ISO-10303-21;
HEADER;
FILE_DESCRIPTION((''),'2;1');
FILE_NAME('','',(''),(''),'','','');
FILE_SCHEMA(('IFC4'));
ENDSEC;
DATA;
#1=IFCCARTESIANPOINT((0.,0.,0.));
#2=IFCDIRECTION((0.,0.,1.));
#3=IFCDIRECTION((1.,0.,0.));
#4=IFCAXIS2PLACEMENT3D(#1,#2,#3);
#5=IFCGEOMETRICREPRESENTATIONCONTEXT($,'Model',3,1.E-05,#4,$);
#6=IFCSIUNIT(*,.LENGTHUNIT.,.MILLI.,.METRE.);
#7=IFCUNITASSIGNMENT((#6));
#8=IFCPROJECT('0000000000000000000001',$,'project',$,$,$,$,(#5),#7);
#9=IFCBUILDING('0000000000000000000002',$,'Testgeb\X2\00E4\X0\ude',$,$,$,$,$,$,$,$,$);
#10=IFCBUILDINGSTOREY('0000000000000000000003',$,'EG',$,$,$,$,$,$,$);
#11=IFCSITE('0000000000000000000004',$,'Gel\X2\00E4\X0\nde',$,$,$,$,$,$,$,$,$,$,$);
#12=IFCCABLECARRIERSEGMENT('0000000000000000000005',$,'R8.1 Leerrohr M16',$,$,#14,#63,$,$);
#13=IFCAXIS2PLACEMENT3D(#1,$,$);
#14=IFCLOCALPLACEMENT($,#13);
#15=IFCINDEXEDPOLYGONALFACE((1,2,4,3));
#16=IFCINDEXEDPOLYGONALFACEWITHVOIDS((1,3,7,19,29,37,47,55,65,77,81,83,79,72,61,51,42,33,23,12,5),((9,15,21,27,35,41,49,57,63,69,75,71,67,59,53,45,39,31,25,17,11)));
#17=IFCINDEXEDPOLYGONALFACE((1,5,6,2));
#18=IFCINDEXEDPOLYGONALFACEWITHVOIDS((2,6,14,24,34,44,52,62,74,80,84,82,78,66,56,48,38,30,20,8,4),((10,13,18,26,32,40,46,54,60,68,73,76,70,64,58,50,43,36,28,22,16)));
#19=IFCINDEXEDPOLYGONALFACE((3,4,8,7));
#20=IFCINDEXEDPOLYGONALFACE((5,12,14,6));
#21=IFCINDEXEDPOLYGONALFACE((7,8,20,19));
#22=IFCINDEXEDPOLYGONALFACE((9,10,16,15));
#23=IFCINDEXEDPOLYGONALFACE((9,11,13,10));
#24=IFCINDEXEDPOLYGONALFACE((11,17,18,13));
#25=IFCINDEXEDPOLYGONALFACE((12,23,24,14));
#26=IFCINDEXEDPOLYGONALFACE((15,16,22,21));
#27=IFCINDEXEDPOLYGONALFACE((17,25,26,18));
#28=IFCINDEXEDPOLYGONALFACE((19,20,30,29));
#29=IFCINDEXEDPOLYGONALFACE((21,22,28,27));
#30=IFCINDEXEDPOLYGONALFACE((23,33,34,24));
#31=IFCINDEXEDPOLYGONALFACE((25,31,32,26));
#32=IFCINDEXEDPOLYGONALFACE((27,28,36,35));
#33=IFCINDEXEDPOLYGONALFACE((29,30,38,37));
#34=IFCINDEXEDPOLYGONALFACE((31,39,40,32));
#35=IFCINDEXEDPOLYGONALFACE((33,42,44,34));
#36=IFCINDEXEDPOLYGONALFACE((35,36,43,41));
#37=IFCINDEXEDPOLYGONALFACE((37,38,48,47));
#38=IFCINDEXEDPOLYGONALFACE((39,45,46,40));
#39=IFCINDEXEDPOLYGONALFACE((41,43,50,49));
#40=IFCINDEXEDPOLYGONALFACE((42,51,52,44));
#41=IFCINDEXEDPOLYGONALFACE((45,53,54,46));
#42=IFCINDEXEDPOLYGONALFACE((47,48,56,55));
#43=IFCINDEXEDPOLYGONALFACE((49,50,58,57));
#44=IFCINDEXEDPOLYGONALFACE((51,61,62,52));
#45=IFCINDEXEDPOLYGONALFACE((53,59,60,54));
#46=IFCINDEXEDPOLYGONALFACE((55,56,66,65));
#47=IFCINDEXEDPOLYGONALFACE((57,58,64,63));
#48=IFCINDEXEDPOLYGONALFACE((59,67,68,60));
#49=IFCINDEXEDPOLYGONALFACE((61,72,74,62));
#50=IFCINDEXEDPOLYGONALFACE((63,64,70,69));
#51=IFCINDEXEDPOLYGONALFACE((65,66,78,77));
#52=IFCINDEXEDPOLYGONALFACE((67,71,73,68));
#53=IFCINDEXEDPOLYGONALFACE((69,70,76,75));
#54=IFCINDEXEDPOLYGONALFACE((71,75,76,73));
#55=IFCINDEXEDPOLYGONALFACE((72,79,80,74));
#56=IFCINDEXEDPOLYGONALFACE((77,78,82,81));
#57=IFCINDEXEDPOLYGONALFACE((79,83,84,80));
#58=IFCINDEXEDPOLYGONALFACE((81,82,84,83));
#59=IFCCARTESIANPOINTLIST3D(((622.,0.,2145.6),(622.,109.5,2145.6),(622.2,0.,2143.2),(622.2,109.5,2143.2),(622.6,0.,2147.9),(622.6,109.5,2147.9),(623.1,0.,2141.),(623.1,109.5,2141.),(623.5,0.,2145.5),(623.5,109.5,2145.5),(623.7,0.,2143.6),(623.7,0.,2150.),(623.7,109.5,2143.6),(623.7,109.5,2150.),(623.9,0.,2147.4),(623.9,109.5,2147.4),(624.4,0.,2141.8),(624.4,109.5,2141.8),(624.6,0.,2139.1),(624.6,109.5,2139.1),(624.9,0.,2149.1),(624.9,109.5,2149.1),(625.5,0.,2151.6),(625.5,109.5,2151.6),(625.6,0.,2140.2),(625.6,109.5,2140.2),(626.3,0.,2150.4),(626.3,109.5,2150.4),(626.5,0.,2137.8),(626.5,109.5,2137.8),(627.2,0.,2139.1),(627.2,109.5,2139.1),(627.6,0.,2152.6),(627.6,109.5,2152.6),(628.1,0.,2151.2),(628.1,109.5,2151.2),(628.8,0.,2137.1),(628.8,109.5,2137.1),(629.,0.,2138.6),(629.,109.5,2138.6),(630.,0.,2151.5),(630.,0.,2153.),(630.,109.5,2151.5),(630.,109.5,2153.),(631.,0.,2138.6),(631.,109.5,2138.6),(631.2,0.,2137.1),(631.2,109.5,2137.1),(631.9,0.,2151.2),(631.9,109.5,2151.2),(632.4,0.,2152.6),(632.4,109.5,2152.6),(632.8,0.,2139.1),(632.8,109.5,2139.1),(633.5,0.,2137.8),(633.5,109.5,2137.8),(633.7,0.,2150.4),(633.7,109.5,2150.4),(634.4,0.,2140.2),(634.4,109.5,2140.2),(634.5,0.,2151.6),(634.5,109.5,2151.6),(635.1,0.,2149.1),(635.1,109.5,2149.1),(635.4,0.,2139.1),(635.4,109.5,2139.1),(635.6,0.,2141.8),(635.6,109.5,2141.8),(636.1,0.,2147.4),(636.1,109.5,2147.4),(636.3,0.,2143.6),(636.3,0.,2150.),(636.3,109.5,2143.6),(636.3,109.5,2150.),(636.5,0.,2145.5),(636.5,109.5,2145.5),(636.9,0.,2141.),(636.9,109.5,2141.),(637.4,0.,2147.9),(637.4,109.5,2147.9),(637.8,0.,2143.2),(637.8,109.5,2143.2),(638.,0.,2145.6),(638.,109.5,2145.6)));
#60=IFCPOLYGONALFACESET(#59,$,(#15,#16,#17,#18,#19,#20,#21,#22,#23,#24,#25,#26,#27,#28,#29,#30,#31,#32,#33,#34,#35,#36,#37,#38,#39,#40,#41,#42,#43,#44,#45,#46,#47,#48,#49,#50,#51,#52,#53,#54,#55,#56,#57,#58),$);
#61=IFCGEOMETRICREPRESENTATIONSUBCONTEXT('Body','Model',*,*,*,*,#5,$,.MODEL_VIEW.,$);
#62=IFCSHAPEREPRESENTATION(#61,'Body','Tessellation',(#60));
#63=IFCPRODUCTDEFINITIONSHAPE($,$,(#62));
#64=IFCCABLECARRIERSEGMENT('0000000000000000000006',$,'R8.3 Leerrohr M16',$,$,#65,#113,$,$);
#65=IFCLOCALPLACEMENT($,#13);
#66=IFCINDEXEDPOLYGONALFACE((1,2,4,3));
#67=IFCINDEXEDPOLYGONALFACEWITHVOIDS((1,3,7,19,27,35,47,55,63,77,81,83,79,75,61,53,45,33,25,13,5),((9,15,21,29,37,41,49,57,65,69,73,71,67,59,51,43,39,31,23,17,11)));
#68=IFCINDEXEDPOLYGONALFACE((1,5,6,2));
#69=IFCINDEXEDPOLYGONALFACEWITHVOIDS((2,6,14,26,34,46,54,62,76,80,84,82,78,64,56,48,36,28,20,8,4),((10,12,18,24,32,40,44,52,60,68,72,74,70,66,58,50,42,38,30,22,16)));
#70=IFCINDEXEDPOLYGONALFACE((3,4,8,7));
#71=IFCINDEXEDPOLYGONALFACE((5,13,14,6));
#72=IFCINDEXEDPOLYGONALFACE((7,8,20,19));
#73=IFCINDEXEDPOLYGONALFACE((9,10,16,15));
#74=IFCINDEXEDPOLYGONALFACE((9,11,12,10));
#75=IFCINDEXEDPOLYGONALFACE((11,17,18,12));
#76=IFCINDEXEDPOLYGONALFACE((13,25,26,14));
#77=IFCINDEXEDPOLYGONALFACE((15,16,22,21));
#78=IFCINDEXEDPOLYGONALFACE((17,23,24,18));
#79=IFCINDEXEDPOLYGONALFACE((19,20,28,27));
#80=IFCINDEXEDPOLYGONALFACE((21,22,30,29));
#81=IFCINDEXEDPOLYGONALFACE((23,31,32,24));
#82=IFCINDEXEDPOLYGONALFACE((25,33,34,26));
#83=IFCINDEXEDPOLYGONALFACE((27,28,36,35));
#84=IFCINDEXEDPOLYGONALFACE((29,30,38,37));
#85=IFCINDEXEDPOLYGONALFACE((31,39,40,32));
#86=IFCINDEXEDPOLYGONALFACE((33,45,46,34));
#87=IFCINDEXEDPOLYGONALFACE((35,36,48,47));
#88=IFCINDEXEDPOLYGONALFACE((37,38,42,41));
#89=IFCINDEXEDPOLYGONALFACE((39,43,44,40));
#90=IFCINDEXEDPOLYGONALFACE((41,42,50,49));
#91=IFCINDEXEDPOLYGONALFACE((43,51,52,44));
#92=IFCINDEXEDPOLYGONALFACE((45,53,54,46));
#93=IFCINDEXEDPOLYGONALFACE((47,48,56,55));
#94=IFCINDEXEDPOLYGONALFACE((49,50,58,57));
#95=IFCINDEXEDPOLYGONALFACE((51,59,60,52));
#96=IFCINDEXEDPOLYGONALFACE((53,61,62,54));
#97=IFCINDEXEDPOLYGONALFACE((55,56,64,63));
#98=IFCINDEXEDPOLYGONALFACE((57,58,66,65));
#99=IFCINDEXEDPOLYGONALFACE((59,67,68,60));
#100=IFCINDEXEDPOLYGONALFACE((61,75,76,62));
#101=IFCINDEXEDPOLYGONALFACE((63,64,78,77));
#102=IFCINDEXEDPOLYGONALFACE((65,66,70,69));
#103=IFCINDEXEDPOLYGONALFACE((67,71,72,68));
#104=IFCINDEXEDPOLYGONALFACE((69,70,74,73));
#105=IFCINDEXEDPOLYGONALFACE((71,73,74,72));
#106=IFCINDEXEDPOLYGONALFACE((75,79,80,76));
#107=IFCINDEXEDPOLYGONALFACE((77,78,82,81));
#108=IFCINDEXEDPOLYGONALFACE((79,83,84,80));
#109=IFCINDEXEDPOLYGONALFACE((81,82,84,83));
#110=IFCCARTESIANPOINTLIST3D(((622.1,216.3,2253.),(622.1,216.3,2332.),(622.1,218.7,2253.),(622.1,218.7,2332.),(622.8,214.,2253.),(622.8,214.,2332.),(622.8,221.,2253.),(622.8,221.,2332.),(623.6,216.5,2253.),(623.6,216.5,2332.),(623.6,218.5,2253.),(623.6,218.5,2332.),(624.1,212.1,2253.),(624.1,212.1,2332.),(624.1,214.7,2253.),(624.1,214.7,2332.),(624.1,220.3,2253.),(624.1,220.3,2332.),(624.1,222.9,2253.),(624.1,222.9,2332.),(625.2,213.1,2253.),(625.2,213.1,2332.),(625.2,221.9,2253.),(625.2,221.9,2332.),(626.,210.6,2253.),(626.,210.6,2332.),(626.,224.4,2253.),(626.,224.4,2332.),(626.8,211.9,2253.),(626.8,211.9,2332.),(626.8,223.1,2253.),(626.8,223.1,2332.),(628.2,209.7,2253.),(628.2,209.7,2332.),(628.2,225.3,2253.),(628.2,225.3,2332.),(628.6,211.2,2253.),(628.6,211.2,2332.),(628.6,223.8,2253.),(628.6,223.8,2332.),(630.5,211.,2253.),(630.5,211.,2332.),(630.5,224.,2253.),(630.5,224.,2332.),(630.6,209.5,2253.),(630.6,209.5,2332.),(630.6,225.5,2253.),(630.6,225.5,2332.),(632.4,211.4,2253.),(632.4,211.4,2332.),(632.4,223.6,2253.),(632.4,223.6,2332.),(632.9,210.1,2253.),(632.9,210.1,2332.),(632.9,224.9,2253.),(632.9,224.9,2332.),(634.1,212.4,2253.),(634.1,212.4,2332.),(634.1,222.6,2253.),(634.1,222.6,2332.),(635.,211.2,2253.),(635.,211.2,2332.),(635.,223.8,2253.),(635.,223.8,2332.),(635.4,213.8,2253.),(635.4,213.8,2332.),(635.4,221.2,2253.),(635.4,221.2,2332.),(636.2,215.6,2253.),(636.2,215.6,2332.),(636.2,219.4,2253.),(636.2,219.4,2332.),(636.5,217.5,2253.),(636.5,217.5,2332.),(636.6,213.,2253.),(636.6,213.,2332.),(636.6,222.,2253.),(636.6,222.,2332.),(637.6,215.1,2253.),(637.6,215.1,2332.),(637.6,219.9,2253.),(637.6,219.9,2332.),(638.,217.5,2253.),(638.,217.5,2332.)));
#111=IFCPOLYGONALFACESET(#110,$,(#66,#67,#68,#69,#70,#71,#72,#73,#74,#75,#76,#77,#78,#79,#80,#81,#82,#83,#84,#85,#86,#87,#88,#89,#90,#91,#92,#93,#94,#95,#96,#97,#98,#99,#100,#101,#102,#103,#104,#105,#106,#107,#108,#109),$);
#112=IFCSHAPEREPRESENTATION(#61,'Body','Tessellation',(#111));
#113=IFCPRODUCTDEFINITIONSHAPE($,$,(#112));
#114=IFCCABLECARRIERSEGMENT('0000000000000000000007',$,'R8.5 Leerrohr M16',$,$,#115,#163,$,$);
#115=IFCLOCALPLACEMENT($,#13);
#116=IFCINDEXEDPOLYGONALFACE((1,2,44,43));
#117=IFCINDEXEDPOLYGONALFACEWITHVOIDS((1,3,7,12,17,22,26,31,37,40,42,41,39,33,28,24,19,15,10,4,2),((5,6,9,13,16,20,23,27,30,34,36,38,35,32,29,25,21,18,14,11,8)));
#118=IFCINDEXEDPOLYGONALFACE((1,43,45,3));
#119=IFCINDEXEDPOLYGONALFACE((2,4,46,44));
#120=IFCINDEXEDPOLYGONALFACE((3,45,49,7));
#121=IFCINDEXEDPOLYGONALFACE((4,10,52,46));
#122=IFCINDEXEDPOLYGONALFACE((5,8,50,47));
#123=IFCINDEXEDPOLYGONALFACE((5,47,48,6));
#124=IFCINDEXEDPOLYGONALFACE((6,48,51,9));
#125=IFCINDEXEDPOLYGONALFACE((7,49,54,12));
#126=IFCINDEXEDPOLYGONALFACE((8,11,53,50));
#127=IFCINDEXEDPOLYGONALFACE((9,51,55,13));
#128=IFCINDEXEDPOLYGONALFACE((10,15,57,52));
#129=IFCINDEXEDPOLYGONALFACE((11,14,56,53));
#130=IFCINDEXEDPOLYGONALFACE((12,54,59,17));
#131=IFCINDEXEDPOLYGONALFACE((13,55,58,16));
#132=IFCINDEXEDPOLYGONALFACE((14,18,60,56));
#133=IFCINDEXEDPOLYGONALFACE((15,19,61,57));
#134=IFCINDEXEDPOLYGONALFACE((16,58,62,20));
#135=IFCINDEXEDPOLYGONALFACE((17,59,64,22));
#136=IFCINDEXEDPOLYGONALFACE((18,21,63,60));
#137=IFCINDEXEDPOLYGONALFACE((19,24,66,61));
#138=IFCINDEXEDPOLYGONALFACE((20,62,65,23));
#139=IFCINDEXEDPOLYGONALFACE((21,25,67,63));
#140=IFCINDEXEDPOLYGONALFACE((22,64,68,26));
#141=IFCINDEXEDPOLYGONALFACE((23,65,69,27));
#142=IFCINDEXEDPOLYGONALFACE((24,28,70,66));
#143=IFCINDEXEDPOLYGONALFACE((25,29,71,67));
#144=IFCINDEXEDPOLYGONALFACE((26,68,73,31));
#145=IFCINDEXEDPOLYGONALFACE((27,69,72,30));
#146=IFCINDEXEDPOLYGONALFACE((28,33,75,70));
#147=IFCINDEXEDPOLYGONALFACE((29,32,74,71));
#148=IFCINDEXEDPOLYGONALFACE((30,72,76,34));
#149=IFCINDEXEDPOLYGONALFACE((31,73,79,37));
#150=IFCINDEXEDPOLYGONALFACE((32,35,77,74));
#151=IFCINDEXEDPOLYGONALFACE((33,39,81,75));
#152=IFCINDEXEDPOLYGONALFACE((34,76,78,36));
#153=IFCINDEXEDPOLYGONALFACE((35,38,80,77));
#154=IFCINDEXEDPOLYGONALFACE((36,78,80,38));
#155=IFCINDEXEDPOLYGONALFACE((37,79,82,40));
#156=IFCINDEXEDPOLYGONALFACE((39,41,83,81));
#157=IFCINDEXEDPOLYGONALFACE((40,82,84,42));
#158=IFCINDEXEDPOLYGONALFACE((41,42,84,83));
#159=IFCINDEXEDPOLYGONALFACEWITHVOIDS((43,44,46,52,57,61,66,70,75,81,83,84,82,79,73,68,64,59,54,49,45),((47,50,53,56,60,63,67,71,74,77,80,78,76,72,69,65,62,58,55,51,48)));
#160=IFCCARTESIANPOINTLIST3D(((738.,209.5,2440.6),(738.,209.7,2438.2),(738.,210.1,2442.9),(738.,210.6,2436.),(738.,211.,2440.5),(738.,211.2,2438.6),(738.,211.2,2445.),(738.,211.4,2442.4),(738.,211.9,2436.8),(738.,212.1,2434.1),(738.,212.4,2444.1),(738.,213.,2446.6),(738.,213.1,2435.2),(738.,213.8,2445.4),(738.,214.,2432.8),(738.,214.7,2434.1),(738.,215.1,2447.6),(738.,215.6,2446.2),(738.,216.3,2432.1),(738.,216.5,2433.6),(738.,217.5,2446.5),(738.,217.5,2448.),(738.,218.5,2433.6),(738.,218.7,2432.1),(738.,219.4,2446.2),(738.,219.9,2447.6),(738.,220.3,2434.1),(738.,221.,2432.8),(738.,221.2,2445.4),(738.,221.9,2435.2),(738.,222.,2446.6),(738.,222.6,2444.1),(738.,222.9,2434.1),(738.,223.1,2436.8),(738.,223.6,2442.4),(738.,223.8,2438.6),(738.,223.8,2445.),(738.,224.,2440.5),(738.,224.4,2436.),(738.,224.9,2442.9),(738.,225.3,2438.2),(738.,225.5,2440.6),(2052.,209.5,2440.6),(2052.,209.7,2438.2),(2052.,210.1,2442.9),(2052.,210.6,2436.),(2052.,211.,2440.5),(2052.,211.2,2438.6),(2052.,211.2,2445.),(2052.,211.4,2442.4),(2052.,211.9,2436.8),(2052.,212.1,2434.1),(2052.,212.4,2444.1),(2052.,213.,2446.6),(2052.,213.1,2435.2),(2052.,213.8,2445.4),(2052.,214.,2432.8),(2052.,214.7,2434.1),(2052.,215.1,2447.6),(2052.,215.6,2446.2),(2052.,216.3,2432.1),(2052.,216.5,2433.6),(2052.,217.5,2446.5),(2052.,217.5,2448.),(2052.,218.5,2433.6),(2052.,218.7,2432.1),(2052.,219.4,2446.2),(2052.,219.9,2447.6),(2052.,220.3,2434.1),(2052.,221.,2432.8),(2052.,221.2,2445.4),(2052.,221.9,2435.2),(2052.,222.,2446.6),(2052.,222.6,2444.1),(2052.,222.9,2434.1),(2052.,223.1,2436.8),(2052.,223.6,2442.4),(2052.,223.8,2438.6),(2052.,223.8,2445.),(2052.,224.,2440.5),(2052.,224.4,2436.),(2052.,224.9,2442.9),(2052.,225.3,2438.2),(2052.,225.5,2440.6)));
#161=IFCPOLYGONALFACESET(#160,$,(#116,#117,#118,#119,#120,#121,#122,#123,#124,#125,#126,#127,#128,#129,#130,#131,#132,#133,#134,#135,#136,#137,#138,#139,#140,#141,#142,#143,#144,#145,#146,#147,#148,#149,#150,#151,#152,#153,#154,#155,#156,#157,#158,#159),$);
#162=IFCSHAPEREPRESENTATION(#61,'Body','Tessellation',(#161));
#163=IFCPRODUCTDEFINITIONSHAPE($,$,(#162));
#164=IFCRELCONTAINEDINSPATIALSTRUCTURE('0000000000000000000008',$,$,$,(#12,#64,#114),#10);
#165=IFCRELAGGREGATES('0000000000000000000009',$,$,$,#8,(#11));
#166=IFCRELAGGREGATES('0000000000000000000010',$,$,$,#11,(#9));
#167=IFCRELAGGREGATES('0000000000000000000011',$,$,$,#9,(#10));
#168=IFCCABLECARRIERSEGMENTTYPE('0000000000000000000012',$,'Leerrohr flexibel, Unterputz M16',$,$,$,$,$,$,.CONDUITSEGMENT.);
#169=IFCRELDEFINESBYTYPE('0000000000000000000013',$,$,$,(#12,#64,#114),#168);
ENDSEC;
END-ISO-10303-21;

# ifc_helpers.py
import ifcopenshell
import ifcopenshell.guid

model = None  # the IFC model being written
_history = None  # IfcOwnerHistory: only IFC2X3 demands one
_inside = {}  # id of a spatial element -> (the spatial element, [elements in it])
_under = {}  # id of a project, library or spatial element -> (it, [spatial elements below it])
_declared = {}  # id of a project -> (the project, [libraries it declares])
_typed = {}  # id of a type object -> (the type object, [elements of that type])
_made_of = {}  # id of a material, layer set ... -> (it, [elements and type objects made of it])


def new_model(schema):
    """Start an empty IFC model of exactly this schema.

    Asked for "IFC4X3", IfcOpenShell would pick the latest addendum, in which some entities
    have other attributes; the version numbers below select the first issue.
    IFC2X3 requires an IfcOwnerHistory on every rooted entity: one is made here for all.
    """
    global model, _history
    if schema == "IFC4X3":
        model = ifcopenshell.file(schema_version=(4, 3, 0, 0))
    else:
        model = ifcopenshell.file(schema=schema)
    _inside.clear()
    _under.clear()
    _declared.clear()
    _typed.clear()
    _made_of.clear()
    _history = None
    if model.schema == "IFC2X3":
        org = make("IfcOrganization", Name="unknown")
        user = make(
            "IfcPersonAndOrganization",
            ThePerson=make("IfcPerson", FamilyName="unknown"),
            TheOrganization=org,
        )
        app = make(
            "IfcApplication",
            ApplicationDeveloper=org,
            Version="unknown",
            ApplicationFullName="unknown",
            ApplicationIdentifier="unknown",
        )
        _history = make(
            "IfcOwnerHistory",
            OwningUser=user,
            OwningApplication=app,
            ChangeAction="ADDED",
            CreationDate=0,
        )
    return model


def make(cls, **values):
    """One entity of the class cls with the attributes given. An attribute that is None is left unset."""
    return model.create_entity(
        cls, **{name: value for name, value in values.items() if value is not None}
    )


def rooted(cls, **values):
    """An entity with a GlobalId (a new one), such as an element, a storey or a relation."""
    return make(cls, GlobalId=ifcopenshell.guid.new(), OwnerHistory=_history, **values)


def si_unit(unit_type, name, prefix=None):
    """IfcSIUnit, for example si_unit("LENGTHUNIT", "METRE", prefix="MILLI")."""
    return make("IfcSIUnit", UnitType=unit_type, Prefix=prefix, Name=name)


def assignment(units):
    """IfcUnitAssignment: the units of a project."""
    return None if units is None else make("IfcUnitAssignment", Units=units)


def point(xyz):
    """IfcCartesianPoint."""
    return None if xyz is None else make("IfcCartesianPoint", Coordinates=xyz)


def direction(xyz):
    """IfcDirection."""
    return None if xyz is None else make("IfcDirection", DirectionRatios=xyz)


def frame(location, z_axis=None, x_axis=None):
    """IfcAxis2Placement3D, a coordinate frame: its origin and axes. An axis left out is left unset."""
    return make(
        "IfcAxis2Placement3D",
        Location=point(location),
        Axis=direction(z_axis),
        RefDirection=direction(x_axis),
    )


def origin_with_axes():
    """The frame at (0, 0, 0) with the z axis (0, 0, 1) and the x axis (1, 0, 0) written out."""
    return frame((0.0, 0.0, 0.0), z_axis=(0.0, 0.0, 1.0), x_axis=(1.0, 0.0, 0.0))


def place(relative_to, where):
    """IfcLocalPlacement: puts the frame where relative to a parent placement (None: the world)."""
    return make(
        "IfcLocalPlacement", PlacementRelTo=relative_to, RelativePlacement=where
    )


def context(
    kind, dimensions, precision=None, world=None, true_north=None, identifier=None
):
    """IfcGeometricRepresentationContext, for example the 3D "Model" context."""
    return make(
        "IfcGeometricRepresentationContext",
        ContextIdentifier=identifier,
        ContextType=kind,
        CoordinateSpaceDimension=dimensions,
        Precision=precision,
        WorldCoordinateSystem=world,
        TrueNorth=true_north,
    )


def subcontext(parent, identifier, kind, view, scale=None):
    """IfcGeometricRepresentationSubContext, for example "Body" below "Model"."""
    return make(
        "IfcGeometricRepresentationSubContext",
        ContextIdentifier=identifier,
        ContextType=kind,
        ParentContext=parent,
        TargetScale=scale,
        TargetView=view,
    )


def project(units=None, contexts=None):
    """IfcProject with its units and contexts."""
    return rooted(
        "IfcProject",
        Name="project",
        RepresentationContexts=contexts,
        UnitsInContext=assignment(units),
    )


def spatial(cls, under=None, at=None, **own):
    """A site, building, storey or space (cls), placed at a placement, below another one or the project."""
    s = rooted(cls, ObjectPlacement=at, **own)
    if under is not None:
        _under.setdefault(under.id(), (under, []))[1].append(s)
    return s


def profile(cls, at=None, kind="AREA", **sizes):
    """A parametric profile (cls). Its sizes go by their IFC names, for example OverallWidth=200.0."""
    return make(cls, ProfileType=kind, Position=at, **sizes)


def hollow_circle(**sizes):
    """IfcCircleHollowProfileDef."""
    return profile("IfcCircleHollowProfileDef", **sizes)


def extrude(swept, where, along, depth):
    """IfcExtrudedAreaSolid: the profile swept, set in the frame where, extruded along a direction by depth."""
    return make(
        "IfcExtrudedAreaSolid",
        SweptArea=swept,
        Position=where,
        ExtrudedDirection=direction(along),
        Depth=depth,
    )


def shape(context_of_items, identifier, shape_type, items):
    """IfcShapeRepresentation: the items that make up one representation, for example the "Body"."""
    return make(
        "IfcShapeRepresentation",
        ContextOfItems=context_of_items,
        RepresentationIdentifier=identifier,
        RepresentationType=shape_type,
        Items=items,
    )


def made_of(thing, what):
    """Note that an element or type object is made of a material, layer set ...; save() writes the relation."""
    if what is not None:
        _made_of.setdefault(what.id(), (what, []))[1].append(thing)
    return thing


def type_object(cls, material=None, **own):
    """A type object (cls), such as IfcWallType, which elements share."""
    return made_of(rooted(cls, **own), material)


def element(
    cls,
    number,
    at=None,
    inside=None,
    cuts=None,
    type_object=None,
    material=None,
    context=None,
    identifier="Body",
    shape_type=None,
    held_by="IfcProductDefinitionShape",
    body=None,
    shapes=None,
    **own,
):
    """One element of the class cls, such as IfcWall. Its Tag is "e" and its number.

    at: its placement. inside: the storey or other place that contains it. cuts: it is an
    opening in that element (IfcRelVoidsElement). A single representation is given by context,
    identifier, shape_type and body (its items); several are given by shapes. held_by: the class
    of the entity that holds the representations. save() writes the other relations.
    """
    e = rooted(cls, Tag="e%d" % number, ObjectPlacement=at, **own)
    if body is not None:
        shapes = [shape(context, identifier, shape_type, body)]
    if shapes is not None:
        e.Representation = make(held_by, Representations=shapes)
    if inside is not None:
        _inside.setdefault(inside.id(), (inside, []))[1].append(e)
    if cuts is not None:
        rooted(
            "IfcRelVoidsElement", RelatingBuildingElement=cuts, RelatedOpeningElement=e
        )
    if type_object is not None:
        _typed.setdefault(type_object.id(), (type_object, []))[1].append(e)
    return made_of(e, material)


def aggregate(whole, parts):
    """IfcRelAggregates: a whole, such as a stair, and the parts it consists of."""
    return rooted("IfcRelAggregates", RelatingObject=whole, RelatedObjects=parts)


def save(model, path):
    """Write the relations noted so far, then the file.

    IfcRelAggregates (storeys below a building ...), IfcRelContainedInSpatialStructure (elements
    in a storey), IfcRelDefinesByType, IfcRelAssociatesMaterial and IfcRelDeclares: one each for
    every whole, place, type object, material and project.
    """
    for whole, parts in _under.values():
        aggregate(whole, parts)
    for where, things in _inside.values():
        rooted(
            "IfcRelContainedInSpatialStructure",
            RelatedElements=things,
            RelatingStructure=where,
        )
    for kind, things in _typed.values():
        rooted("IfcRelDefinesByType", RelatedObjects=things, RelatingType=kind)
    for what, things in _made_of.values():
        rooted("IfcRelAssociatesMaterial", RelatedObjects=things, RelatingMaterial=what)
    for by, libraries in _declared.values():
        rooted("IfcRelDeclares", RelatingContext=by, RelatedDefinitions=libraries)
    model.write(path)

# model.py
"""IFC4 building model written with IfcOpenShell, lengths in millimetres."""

from ifc_helpers import new_model, si_unit, frame, origin_with_axes, place, context, subcontext, project, spatial, hollow_circle, extrude, type_object, element, save


model = new_model("IFC4")

# Units and contexts
model_context = context("Model", 3, precision=1e-05, world=origin_with_axes())
body_context = subcontext(model_context, "Body", "Model", "MODEL_VIEW")
ifc_project = project(units=[si_unit("LENGTHUNIT", "METRE", prefix="MILLI")], contexts=[model_context])

# Site, building, storey
site = spatial("IfcSite", under=ifc_project, Name="Gelände")
building = spatial("IfcBuilding", under=site, Name="Testgebäude")
storey = spatial("IfcBuildingStorey", under=building, Name="EG")

# Cable carrier segments
cable_carrier_segment_type_1 = type_object("IfcCableCarrierSegmentType", Name="Leerrohr flexibel, Unterputz M16", PredefinedType="CONDUITSEGMENT")
cable_carrier_segment_1_placement = place(None, frame((630.0, 0.0, 2145.0), z_axis=(0.0, 1.0, 0.0), x_axis=(0.0, 0.0, 1.0)))
element("IfcCableCarrierSegment", 1, at=cable_carrier_segment_1_placement, inside=storey, type_object=cable_carrier_segment_type_1, Name="R8.1 Leerrohr M16", context=body_context, shape_type="SweptSolid", body=[
    extrude(hollow_circle(Radius=8.0, WallThickness=1.5), None, (0.0, 0.0, 1.0), 109.5),
])
cable_carrier_segment_2_placement = place(None, frame((630.0, 217.5, 2253.0), z_axis=(0.0, 0.0, 1.0), x_axis=(1.0, 0.0, 0.0)))
element("IfcCableCarrierSegment", 2, at=cable_carrier_segment_2_placement, inside=storey, type_object=cable_carrier_segment_type_1, Name="R8.3 Leerrohr M16", context=body_context, shape_type="SweptSolid", body=[
    extrude(hollow_circle(Radius=8.0, WallThickness=1.5), None, (0.0, 0.0, 1.0), 79.0),
])
cable_carrier_segment_3_placement = place(None, frame((738.0, 217.5, 2440.0), z_axis=(1.0, 0.0, 0.0), x_axis=(0.0, 0.0, 1.0)))
element("IfcCableCarrierSegment", 3, at=cable_carrier_segment_3_placement, inside=storey, type_object=cable_carrier_segment_type_1, Name="R8.5 Leerrohr M16", context=body_context, shape_type="SweptSolid", body=[
    extrude(hollow_circle(Radius=8.0, WallThickness=1.5), None, (0.0, 0.0, 1.0), 1314.0),
])

save(model, "model.ifc")
